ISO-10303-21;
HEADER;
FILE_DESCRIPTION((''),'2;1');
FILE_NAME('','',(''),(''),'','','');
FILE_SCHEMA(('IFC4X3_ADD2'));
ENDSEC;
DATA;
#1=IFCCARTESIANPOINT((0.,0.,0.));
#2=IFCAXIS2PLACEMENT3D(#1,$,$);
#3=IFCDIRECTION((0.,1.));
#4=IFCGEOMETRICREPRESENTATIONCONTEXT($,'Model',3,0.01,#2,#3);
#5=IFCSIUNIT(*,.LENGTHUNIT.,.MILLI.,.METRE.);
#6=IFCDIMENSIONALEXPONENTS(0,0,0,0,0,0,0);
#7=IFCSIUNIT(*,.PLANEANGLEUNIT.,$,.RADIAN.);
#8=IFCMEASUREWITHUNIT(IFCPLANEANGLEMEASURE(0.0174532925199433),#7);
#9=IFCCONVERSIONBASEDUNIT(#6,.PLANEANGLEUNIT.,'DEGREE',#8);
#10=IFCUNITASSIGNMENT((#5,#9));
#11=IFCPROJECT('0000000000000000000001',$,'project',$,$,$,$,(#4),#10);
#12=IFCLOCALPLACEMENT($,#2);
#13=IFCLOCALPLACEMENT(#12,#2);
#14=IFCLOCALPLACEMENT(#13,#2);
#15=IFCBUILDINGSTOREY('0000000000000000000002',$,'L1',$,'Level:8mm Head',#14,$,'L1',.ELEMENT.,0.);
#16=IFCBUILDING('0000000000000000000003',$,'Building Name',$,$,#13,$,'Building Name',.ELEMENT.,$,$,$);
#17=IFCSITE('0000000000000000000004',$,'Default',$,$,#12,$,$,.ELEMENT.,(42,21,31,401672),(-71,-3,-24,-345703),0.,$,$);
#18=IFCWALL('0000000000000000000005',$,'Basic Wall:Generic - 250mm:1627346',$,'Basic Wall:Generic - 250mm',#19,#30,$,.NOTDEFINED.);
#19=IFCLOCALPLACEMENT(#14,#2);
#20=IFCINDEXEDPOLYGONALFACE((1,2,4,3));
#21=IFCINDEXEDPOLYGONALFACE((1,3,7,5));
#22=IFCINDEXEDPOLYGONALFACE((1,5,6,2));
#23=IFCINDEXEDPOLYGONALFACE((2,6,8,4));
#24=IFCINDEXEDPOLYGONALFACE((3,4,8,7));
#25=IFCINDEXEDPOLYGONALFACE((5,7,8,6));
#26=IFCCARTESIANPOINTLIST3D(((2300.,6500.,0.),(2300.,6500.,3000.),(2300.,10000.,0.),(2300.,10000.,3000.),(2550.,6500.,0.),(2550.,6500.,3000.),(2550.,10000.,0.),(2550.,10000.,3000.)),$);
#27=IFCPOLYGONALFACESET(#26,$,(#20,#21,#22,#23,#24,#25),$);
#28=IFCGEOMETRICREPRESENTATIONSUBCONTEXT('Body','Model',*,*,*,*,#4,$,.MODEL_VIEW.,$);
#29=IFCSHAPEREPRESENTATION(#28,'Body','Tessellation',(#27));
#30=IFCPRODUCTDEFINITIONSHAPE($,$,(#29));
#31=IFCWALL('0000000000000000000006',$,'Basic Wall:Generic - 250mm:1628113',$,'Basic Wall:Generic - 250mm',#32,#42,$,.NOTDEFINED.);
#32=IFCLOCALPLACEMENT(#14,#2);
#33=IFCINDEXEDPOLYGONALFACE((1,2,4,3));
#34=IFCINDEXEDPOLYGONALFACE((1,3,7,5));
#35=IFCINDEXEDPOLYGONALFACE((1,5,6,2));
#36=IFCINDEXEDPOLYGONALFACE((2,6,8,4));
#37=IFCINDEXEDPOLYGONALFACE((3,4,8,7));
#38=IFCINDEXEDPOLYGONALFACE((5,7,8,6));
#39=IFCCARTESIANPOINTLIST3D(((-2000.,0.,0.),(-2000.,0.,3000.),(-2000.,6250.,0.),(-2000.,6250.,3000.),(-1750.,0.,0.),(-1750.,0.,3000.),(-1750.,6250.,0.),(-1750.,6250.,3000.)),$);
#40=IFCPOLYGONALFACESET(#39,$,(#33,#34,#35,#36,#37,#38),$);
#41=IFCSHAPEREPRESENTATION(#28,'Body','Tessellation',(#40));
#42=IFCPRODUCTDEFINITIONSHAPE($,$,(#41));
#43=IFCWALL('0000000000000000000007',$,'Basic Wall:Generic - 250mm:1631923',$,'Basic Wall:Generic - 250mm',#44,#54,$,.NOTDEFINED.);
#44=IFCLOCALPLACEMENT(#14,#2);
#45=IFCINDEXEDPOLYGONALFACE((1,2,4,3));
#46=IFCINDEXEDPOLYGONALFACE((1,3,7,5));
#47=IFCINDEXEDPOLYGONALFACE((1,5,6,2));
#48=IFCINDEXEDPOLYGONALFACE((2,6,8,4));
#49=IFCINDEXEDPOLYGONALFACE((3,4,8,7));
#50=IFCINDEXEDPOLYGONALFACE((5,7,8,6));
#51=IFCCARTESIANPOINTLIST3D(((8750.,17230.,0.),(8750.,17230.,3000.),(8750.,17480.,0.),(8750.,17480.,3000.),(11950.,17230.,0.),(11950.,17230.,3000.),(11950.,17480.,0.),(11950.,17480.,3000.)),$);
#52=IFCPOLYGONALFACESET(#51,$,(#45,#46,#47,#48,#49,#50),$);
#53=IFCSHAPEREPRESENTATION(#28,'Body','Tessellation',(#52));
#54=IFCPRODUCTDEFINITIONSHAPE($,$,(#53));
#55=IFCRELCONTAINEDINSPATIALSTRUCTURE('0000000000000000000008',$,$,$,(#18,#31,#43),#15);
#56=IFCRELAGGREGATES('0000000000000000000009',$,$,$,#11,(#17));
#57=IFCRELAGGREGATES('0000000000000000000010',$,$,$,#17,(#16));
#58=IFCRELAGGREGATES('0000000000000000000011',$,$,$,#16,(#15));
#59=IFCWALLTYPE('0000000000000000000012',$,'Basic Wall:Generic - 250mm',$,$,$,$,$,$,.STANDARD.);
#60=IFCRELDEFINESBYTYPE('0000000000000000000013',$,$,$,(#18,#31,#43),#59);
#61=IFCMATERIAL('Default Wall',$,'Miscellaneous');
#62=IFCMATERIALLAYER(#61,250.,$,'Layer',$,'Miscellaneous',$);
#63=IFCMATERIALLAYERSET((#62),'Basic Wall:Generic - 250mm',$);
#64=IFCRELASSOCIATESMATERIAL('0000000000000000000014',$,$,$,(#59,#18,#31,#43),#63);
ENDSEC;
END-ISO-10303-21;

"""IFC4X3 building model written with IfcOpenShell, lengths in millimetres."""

from ifc_helpers import new_model, entity, si_unit, converted_unit, direction, frame, frame_2d, origin, place, context, subcontext, project, spatial, rectangle, extrude, material, layer, layer_set, type_object, element, save


model = new_model("IFC4X3")

# Units and contexts
model_context = context("Model", 3, precision=0.01, world=origin(), true_north=direction((0.0, 1.0)))
body_context = subcontext(model_context, "Body", "Model", "MODEL_VIEW")
ifc_project = project(units=[si_unit("LENGTHUNIT", "METRE", prefix="MILLI"), converted_unit("PLANEANGLEUNIT", "DEGREE", entity("IfcPlaneAngleMeasure", 0.0174532925199433), si_unit("PLANEANGLEUNIT", "RADIAN"), dimensions=[0, 0, 0, 0, 0, 0, 0])], contexts=[model_context])

# Site, building, storey
site_placement = place(None, origin())
site = spatial("IfcSite", under=ifc_project, at=site_placement, Name="Default", CompositionType="ELEMENT", RefLatitude=(42, 21, 31, 401672), RefLongitude=(-71, -3, -24, -345703), RefElevation=0.0)
building_placement = place(site_placement, origin())
building = spatial("IfcBuilding", under=site, at=building_placement, Name="Building Name", LongName="Building Name", CompositionType="ELEMENT")
storey_placement = place(building_placement, origin())
storey = spatial("IfcBuildingStorey", under=building, at=storey_placement, Name="L1", ObjectType="Level:8mm Head", LongName="L1", CompositionType="ELEMENT", Elevation=0.0)

# Shared definitions
ifc_material = material(Name="Default Wall", Category="Miscellaneous")
ifc_layer = layer(ifc_material, 250.0, Name="Layer", Category="Miscellaneous")
ifc_layer_set = layer_set([ifc_layer], Name="Basic Wall:Generic - 250mm")
wall_type = type_object("IfcWallType", Name="Basic Wall:Generic - 250mm", PredefinedType="STANDARD", material=ifc_layer_set)

# Walls
wall_1_placement = place(storey_placement, frame((2425.0, 6500.0, 0.0), z_axis=(0.0, 0.0, 1.0), x_axis=(0.0, 1.0, 0.0)))
element("IfcWall", 1, at=wall_1_placement, inside=storey, type_object=wall_type, material=ifc_layer_set, Name="Basic Wall:Generic - 250mm:1627346", ObjectType="Basic Wall:Generic - 250mm", PredefinedType="NOTDEFINED", context=body_context, shape_type="SweptSolid", body=[
    extrude(rectangle(XDim=3500.0, YDim=250.0, at=frame_2d((1750.0, 0.0), x_axis=(-1.0, 0.0))), origin(), (0.0, 0.0, 1.0), 3000.0),
])
wall_2_placement = place(storey_placement, frame((-1875.0, 6250.0, 0.0), z_axis=(0.0, 0.0, 1.0), x_axis=(0.0, -1.0, 0.0)))
element("IfcWall", 2, at=wall_2_placement, inside=storey, type_object=wall_type, material=ifc_layer_set, Name="Basic Wall:Generic - 250mm:1628113", ObjectType="Basic Wall:Generic - 250mm", PredefinedType="NOTDEFINED", context=body_context, shape_type="SweptSolid", body=[
    extrude(rectangle(XDim=6250.0, YDim=250.0, at=frame_2d((3125.0, 0.0), x_axis=(-1.0, 0.0))), origin(), (0.0, 0.0, 1.0), 3000.0),
])
wall_3_placement = place(storey_placement, frame((11950.0, 17355.0, 0.0), z_axis=(0.0, 0.0, 1.0), x_axis=(-1.0, 0.0, 0.0)))
element("IfcWall", 3, at=wall_3_placement, inside=storey, type_object=wall_type, material=ifc_layer_set, Name="Basic Wall:Generic - 250mm:1631923", ObjectType="Basic Wall:Generic - 250mm", PredefinedType="NOTDEFINED", context=body_context, shape_type="SweptSolid", body=[
    extrude(rectangle(XDim=3200.0, YDim=250.0, at=frame_2d((1600.0, 0.0), x_axis=(-1.0, 0.0))), origin(), (0.0, 0.0, 1.0), 3000.0),
])

save(model, "model.ifc")
